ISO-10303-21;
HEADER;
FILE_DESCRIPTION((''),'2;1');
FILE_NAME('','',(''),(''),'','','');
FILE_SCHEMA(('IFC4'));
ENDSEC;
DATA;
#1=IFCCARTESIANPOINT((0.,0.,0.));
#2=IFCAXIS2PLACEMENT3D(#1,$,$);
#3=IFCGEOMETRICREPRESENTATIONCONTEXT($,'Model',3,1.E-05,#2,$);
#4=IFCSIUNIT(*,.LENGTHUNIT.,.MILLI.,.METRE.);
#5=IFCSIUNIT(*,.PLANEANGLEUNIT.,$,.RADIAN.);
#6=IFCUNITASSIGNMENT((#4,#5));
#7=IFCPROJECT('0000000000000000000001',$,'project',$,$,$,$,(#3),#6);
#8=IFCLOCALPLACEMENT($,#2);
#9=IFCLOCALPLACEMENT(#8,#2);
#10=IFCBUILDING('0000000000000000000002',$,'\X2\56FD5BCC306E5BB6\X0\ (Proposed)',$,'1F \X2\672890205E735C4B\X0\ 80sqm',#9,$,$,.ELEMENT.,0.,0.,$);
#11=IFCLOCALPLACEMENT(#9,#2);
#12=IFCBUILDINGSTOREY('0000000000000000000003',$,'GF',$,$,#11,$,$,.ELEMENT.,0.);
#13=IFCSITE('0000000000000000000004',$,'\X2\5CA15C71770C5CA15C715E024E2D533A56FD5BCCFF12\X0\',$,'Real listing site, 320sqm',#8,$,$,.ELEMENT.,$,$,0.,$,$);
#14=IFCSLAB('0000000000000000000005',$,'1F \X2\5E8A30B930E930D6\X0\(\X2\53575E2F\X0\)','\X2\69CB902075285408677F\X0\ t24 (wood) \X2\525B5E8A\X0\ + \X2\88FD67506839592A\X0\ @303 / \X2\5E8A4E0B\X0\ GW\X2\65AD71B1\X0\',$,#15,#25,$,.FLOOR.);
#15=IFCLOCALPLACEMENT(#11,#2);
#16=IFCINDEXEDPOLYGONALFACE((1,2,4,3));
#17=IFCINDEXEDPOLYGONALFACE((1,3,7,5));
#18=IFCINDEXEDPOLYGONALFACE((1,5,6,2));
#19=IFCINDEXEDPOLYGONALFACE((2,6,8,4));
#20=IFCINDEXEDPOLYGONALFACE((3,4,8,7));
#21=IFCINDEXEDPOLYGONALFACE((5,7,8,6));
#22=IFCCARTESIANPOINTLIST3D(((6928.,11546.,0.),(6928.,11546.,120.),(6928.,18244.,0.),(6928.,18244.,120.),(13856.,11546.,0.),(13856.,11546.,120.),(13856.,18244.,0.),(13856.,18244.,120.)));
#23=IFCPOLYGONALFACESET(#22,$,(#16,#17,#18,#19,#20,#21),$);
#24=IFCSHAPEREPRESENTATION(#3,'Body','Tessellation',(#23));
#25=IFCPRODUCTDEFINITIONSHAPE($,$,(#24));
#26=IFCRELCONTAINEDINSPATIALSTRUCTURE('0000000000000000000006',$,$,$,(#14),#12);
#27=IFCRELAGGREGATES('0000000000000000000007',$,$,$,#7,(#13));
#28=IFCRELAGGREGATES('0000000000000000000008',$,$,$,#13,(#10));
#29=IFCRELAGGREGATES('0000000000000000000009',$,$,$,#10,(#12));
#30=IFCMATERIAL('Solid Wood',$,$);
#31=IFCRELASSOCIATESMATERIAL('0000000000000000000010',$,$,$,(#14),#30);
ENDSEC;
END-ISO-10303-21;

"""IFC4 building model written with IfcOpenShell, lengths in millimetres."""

from ifc_helpers import new_model, si_unit, frame, frame_2d, origin, place, context, project, spatial, rectangle, extrude, material, element, save


model = new_model("IFC4")

# Units and contexts
model_context = context("Model", 3, precision=1e-05, world=origin())
ifc_project = project(units=[si_unit("LENGTHUNIT", "METRE", prefix="MILLI"), si_unit("PLANEANGLEUNIT", "RADIAN")], contexts=[model_context])

# Site, building, storey
site_placement = place(None, origin())
site = spatial("IfcSite", under=ifc_project, at=site_placement, Name="岡山県岡山市中区国富２", ObjectType="Real listing site, 320sqm", CompositionType="ELEMENT", RefElevation=0.0)
building_placement = place(site_placement, origin())
building = spatial("IfcBuilding", under=site, at=building_placement, Name="国富の家 (Proposed)", ObjectType="1F 木造平屋 80sqm", CompositionType="ELEMENT", ElevationOfRefHeight=0.0, ElevationOfTerrain=0.0)
storey_placement = place(building_placement, origin())
storey = spatial("IfcBuildingStorey", under=building, at=storey_placement, Name="GF", CompositionType="ELEMENT", Elevation=0.0)

# Slab
ifc_material_1 = material(Name="Solid Wood")
slab_1_placement = place(storey_placement, frame((3464.0, 5773.0, 0.0)))
element("IfcSlab", 1, at=slab_1_placement, inside=storey, material=ifc_material_1, Name="1F 床スラブ(南帯)", Description="構造用合板 t24 (wood) 剛床 + 製材根太 @303 / 床下 GW断熱", PredefinedType="FLOOR", context=model_context, shape_type="SweptSolid", body=[
    extrude(rectangle(XDim=6928.0, YDim=6698.0, at=frame_2d((3464.0, 3349.0))), frame((3464.0, 5773.0, 0.0)), (0.0, 0.0, 1.0), 120.0),
])

save(model, "model.ifc")
